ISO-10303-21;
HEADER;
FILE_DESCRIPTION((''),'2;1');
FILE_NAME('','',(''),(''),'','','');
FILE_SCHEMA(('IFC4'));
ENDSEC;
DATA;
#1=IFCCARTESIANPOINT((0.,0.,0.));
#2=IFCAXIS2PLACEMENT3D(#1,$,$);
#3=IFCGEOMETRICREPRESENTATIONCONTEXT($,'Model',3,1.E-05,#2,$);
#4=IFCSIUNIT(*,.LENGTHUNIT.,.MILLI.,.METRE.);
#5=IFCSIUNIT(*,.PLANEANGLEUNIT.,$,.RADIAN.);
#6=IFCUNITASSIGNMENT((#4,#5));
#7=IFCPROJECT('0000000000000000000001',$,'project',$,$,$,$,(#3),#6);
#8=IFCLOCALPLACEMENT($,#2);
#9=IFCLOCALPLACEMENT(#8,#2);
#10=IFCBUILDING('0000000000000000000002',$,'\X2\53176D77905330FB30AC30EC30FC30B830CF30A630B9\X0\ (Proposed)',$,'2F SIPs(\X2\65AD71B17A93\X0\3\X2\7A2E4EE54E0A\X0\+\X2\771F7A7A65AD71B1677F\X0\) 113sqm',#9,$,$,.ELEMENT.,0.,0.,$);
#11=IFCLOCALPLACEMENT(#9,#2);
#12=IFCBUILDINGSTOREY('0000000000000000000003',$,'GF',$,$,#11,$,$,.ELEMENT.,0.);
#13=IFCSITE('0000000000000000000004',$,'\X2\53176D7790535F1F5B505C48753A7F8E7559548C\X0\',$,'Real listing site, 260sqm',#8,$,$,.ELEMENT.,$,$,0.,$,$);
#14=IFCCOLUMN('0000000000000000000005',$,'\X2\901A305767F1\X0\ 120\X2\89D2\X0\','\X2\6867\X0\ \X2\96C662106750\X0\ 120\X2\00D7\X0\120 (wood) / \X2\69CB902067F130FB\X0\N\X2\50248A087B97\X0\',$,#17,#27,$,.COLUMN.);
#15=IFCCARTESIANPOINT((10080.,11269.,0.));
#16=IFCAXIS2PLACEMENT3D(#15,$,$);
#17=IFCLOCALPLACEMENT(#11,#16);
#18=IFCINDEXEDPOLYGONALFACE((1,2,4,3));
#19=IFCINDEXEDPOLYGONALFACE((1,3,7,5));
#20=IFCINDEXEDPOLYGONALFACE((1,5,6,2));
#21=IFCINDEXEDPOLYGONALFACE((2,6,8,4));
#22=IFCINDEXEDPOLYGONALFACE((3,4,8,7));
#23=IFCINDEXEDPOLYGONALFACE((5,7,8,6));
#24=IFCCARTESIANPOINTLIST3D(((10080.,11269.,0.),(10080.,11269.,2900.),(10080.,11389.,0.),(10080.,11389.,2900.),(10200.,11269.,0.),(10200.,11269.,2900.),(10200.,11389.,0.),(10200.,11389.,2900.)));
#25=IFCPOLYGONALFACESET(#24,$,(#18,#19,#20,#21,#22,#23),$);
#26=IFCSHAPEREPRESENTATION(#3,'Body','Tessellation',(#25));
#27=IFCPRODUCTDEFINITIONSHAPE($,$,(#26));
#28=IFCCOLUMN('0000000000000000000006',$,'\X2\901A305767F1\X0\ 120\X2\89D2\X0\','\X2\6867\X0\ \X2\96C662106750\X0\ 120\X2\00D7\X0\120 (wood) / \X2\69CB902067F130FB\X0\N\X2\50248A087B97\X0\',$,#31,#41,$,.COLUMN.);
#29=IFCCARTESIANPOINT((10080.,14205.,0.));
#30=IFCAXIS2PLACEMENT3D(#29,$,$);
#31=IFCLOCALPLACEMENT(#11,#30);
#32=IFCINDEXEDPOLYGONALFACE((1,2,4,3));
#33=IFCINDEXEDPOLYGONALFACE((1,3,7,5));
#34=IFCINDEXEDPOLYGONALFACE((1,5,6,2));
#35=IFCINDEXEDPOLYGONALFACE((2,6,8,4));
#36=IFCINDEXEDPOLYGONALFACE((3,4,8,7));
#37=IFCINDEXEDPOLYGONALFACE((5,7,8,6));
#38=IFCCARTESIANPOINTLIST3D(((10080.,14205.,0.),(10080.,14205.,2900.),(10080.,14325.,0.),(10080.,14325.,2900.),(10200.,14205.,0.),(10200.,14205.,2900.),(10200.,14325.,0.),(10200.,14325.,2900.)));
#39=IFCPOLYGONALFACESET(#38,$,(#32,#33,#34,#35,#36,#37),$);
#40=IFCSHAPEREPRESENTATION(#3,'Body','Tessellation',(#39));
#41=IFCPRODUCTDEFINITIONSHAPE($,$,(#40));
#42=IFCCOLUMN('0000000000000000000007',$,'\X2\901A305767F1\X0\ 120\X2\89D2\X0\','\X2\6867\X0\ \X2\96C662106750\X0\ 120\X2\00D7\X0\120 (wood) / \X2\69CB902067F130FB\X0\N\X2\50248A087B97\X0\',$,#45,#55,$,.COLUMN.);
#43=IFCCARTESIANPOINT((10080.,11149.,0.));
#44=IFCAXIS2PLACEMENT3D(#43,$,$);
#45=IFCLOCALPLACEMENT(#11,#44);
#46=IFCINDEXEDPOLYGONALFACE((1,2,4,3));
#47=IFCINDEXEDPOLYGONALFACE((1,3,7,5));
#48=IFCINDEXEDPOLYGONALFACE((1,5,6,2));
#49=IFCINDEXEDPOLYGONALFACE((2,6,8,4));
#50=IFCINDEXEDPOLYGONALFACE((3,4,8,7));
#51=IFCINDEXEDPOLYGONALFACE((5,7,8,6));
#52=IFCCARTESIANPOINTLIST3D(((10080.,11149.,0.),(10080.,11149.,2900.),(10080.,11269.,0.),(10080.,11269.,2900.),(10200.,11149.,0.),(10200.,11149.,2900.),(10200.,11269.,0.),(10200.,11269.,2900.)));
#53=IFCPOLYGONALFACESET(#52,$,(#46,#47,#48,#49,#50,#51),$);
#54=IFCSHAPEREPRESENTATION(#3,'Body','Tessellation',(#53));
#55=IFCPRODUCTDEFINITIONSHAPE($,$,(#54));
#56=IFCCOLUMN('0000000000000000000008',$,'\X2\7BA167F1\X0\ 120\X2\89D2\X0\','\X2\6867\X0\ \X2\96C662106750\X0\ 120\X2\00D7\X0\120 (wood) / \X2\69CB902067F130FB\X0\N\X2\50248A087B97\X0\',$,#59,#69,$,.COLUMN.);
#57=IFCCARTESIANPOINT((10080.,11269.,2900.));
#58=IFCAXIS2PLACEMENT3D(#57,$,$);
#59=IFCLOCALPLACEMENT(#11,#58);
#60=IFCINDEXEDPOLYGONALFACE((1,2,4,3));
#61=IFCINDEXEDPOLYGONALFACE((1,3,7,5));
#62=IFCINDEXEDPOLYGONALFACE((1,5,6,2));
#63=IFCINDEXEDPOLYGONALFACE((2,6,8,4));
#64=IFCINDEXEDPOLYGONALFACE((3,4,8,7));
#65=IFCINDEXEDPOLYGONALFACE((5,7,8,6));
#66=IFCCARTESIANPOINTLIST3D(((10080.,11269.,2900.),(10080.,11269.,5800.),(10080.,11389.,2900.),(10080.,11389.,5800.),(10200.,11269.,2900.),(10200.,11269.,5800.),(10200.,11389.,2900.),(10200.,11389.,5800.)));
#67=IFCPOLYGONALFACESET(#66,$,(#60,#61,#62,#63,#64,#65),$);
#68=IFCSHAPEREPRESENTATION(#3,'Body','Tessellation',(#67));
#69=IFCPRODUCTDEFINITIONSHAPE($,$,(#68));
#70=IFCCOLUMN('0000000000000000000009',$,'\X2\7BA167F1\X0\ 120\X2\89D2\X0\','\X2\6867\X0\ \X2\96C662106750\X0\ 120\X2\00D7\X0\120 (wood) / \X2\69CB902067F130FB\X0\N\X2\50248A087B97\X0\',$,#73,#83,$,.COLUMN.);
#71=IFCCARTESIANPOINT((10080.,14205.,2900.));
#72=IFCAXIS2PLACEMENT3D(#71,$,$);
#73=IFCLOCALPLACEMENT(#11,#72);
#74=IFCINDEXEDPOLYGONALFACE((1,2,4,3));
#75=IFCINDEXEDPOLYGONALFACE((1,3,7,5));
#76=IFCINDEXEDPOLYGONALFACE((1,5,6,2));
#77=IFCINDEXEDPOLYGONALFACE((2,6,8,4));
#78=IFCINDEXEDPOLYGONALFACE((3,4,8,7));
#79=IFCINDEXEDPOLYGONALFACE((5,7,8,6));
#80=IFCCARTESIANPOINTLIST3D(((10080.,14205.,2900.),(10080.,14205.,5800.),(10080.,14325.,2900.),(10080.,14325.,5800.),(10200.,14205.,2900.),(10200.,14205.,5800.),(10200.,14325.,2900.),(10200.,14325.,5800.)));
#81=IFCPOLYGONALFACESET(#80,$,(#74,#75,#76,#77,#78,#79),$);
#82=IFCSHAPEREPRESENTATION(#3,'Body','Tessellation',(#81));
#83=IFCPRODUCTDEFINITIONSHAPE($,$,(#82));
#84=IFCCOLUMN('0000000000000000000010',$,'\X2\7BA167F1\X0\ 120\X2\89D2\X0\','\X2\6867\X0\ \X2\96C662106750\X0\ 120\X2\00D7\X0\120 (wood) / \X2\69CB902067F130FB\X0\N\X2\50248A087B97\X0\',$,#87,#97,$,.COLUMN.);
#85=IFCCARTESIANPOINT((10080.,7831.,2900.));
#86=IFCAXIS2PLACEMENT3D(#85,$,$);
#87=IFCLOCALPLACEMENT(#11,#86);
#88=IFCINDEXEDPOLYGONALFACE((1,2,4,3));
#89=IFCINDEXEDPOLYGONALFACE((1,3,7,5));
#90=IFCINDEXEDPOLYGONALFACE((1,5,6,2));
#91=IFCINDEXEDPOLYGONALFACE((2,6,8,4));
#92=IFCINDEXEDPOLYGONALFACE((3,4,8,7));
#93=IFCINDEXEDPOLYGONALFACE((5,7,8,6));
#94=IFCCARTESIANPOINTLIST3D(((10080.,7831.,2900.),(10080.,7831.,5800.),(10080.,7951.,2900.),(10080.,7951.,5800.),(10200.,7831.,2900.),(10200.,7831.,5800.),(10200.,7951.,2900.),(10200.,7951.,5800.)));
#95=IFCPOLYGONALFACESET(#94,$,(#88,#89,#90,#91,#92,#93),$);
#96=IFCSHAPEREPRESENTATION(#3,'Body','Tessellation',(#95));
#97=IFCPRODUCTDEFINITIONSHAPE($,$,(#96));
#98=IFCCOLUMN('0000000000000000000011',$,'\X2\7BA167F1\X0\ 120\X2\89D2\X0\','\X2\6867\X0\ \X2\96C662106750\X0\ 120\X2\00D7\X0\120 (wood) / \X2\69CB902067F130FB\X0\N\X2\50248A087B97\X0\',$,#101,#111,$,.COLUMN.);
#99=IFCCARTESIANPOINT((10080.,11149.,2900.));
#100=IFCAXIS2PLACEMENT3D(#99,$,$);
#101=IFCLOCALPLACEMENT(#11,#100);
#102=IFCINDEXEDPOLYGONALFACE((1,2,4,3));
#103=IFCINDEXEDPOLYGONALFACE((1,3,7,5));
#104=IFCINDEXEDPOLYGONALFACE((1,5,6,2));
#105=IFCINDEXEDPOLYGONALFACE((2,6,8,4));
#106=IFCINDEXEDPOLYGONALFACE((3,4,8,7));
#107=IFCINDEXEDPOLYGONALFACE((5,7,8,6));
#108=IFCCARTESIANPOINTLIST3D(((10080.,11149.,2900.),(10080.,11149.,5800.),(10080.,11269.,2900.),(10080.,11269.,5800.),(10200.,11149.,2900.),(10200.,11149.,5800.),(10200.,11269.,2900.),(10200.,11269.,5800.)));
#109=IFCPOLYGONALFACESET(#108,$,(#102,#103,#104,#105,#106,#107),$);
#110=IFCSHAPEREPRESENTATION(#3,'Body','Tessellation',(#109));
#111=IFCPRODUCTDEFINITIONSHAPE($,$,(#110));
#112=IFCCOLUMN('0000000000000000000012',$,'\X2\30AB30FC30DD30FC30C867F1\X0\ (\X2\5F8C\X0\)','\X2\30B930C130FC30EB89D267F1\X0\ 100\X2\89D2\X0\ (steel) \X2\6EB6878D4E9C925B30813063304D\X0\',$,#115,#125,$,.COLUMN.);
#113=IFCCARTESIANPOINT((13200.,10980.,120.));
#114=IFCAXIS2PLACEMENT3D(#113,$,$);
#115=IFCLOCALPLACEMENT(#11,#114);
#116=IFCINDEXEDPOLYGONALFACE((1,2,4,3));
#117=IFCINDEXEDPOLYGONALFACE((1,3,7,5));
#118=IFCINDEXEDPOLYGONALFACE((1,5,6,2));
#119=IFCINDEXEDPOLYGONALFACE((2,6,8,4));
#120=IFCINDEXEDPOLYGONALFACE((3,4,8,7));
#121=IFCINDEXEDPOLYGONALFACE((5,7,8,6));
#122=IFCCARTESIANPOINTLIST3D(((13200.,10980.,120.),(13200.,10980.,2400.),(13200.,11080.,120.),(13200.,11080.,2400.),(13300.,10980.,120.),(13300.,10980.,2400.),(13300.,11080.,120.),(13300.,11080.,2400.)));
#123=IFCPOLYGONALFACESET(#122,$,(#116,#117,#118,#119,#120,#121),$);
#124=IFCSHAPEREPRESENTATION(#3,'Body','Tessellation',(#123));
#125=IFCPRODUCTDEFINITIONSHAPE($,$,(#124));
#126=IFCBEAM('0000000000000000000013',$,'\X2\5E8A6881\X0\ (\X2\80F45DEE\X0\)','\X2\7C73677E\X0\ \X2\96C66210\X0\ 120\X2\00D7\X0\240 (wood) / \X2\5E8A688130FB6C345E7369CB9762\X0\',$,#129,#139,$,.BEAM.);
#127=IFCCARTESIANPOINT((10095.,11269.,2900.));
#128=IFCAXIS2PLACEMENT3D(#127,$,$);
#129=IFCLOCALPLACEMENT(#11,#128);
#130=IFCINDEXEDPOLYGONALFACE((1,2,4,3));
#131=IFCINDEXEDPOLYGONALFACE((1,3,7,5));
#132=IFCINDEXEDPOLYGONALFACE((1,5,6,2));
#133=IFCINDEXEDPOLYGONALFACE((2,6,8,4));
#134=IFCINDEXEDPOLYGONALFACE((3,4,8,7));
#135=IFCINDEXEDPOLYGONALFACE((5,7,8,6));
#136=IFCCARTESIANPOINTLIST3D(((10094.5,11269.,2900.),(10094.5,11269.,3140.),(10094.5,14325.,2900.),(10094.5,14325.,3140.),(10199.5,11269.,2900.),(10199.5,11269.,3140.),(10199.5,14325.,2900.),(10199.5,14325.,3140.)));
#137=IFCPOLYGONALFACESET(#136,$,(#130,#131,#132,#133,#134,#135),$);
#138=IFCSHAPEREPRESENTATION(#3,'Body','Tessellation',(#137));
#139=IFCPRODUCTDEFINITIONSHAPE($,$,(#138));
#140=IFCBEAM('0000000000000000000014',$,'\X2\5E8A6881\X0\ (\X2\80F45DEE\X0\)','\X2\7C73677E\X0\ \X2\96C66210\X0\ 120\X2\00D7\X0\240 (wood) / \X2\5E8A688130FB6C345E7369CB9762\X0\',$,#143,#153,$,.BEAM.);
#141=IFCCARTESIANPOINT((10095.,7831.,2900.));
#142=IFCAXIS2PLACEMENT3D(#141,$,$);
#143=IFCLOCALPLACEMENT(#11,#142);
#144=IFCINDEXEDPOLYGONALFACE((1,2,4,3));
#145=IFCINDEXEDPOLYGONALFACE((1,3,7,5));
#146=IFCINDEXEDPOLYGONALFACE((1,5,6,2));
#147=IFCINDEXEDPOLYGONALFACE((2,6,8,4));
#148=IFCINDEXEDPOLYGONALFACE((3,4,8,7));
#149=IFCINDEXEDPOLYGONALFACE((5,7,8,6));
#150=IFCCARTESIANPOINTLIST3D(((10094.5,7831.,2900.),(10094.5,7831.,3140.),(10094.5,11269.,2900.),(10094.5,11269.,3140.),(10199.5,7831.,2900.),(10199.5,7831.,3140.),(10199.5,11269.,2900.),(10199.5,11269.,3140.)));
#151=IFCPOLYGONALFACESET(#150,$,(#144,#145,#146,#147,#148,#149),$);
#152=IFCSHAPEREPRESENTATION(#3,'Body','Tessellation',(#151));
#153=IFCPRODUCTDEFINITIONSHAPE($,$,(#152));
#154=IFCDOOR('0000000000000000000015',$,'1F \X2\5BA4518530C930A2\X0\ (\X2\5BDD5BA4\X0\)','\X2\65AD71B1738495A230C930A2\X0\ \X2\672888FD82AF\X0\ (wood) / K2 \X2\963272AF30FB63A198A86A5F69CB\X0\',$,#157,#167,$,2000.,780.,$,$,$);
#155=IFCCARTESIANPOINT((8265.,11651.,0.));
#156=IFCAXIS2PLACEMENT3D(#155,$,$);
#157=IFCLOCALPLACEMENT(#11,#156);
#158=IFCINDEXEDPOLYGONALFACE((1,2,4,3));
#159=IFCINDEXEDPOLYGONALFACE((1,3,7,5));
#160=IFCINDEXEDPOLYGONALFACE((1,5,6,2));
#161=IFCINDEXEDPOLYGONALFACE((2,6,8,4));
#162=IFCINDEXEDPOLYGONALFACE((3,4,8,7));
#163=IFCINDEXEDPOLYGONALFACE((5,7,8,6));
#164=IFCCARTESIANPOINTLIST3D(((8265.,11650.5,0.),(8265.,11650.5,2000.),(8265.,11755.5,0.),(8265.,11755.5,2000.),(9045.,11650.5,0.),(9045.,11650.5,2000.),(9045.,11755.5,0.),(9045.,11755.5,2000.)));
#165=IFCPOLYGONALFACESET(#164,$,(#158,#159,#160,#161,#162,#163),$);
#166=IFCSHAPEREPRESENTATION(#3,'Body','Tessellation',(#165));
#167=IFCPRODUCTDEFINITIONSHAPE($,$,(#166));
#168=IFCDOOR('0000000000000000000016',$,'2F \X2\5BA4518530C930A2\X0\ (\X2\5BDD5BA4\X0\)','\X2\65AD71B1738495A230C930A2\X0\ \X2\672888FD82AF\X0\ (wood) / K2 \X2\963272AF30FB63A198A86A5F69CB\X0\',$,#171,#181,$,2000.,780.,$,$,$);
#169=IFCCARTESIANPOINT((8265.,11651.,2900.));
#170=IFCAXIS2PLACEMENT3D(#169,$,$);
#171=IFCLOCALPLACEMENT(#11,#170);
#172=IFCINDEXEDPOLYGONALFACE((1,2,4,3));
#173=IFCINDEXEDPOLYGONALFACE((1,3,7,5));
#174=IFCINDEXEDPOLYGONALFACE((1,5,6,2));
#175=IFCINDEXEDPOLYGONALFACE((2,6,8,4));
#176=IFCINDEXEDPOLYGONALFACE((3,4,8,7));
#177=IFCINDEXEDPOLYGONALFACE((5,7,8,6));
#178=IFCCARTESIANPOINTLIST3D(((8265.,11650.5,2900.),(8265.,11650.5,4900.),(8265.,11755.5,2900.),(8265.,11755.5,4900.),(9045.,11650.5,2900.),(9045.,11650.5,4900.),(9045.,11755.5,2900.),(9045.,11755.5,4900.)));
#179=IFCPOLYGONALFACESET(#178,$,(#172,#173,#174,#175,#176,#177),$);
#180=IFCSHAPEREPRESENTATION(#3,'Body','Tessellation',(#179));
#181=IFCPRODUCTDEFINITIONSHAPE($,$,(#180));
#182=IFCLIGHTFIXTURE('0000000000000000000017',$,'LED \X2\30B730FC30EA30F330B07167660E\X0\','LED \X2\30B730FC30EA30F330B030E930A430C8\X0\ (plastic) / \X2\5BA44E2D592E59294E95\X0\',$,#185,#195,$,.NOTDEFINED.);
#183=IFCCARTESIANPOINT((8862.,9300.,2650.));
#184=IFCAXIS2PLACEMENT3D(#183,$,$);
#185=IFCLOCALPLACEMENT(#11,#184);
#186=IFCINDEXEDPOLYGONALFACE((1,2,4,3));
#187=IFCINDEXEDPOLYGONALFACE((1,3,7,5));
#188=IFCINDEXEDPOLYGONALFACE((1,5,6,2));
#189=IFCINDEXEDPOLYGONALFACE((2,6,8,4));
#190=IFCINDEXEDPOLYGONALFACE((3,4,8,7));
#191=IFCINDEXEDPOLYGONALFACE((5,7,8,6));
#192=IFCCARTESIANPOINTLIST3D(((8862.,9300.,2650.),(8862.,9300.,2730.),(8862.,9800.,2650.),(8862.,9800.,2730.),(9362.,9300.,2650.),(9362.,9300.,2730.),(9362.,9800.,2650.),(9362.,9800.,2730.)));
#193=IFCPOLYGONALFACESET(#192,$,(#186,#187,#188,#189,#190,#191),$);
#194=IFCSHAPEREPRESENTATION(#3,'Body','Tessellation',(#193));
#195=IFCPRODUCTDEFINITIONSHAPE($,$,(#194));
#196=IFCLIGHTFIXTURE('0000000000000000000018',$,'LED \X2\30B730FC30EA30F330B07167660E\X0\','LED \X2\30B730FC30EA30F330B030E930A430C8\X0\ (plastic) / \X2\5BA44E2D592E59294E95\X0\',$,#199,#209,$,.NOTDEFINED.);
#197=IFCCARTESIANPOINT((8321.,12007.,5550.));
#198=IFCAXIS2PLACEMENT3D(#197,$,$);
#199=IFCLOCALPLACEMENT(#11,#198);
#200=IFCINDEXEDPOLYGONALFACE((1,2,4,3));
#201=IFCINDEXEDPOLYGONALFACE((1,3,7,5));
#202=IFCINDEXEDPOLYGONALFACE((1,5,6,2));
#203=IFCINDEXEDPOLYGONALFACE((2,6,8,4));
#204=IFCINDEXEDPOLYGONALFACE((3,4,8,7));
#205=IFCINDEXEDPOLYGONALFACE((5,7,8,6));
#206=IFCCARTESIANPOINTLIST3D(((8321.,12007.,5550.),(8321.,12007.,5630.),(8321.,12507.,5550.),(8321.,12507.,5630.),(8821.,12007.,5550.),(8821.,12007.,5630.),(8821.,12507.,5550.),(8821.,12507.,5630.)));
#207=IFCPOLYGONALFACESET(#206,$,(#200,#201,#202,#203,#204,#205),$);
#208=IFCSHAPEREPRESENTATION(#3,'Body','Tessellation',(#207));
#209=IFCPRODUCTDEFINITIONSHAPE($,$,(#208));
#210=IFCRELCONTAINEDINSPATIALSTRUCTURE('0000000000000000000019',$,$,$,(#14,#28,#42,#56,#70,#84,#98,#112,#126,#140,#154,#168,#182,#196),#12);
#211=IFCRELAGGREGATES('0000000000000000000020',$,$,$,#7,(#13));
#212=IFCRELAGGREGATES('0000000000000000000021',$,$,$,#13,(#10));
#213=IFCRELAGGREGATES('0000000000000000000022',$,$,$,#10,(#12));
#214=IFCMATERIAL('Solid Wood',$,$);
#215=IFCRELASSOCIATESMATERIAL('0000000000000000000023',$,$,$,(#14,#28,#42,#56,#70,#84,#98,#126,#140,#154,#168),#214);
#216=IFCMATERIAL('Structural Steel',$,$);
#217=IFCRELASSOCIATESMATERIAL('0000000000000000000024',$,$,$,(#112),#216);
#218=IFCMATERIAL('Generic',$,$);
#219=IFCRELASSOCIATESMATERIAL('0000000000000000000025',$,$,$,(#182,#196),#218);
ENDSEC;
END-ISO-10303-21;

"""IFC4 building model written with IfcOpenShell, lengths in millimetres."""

from ifc_helpers import new_model, si_unit, frame, frame_2d, origin, place, context, project, spatial, rectangle, extrude, material, element, save


model = new_model("IFC4")

# Units and contexts
model_context = context("Model", 3, precision=1e-05, world=origin())
ifc_project = project(units=[si_unit("LENGTHUNIT", "METRE", prefix="MILLI"), si_unit("PLANEANGLEUNIT", "RADIAN")], contexts=[model_context])

# Site, building, storey
site_placement = place(None, origin())
site = spatial("IfcSite", under=ifc_project, at=site_placement, Name="北海道弟子屈町美留和", ObjectType="Real listing site, 260sqm", CompositionType="ELEMENT", RefElevation=0.0)
building_placement = place(site_placement, origin())
building = spatial("IfcBuilding", under=site, at=building_placement, Name="北海道・ガレージハウス (Proposed)", ObjectType="2F SIPs(断熱窓3種以上+真空断熱板) 113sqm", CompositionType="ELEMENT", ElevationOfRefHeight=0.0, ElevationOfTerrain=0.0)
storey_placement = place(building_placement, origin())
storey = spatial("IfcBuildingStorey", under=building, at=storey_placement, Name="GF", CompositionType="ELEMENT", Elevation=0.0)

# Columns
ifc_material_1 = material(Name="Solid Wood")
column_1_placement = place(storey_placement, frame((10080.0, 11269.0, 0.0)))
element("IfcColumn", 1, at=column_1_placement, inside=storey, material=ifc_material_1, Name="通し柱 120角", Description="桧 集成材 120×120 (wood) / 構造柱・N値計算", PredefinedType="COLUMN", context=model_context, shape_type="SweptSolid", body=[
    extrude(rectangle(XDim=120.0, YDim=120.0, at=frame_2d((60.0, 60.0))), frame((10080.0, 11269.0, 0.0)), (0.0, 0.0, 1.0), 2900.0),
])
column_2_placement = place(storey_placement, frame((10080.0, 14205.0, 0.0)))
element("IfcColumn", 2, at=column_2_placement, inside=storey, material=ifc_material_1, Name="通し柱 120角", Description="桧 集成材 120×120 (wood) / 構造柱・N値計算", PredefinedType="COLUMN", context=model_context, shape_type="SweptSolid", body=[
    extrude(rectangle(XDim=120.0, YDim=120.0, at=frame_2d((60.0, 60.0))), frame((10080.0, 14205.0, 0.0)), (0.0, 0.0, 1.0), 2900.0),
])
column_3_placement = place(storey_placement, frame((10080.0, 11149.0, 0.0)))
element("IfcColumn", 3, at=column_3_placement, inside=storey, material=ifc_material_1, Name="通し柱 120角", Description="桧 集成材 120×120 (wood) / 構造柱・N値計算", PredefinedType="COLUMN", context=model_context, shape_type="SweptSolid", body=[
    extrude(rectangle(XDim=120.0, YDim=120.0, at=frame_2d((60.0, 60.0))), frame((10080.0, 11149.0, 0.0)), (0.0, 0.0, 1.0), 2900.0),
])
column_4_placement = place(storey_placement, frame((10080.0, 11269.0, 2900.0)))
element("IfcColumn", 4, at=column_4_placement, inside=storey, material=ifc_material_1, Name="管柱 120角", Description="桧 集成材 120×120 (wood) / 構造柱・N値計算", PredefinedType="COLUMN", context=model_context, shape_type="SweptSolid", body=[
    extrude(rectangle(XDim=120.0, YDim=120.0, at=frame_2d((60.0, 60.0))), frame((10080.0, 11269.0, 2900.0)), (0.0, 0.0, 1.0), 2900.0),
])
column_5_placement = place(storey_placement, frame((10080.0, 14205.0, 2900.0)))
element("IfcColumn", 5, at=column_5_placement, inside=storey, material=ifc_material_1, Name="管柱 120角", Description="桧 集成材 120×120 (wood) / 構造柱・N値計算", PredefinedType="COLUMN", context=model_context, shape_type="SweptSolid", body=[
    extrude(rectangle(XDim=120.0, YDim=120.0, at=frame_2d((60.0, 60.0))), frame((10080.0, 14205.0, 2900.0)), (0.0, 0.0, 1.0), 2900.0),
])
column_6_placement = place(storey_placement, frame((10080.0, 7831.0, 2900.0)))
element("IfcColumn", 6, at=column_6_placement, inside=storey, material=ifc_material_1, Name="管柱 120角", Description="桧 集成材 120×120 (wood) / 構造柱・N値計算", PredefinedType="COLUMN", context=model_context, shape_type="SweptSolid", body=[
    extrude(rectangle(XDim=120.0, YDim=120.0, at=frame_2d((60.0, 60.0))), frame((10080.0, 7831.0, 2900.0)), (0.0, 0.0, 1.0), 2900.0),
])
column_7_placement = place(storey_placement, frame((10080.0, 11149.0, 2900.0)))
element("IfcColumn", 7, at=column_7_placement, inside=storey, material=ifc_material_1, Name="管柱 120角", Description="桧 集成材 120×120 (wood) / 構造柱・N値計算", PredefinedType="COLUMN", context=model_context, shape_type="SweptSolid", body=[
    extrude(rectangle(XDim=120.0, YDim=120.0, at=frame_2d((60.0, 60.0))), frame((10080.0, 11149.0, 2900.0)), (0.0, 0.0, 1.0), 2900.0),
])
ifc_material_2 = material(Name="Structural Steel")
column_8_placement = place(storey_placement, frame((13200.0, 10980.0, 120.0)))
element("IfcColumn", 8, at=column_8_placement, inside=storey, material=ifc_material_2, Name="カーポート柱 (後)", Description="スチール角柱 100角 (steel) 溶融亜鉛めっき", PredefinedType="COLUMN", context=model_context, shape_type="SweptSolid", body=[
    extrude(rectangle(XDim=100.0, YDim=100.0, at=frame_2d((50.0, 50.0))), frame((13200.0, 10980.0, 120.0)), (0.0, 0.0, 1.0), 2280.0),
])

# Beams
beam_1_placement = place(storey_placement, frame((10095.0, 11269.0, 2900.0)))
element("IfcBeam", 9, at=beam_1_placement, inside=storey, material=ifc_material_1, Name="床梁 (胴差)", Description="米松 集成 120×240 (wood) / 床梁・水平構面", PredefinedType="BEAM", context=model_context, shape_type="SweptSolid", body=[
    extrude(rectangle(XDim=105.0, YDim=3056.0, at=frame_2d((52.0, 1528.0))), frame((10095.0, 11269.0, 2900.0)), (0.0, 0.0, 1.0), 240.0),
])
beam_2_placement = place(storey_placement, frame((10095.0, 7831.0, 2900.0)))
element("IfcBeam", 10, at=beam_2_placement, inside=storey, material=ifc_material_1, Name="床梁 (胴差)", Description="米松 集成 120×240 (wood) / 床梁・水平構面", PredefinedType="BEAM", context=model_context, shape_type="SweptSolid", body=[
    extrude(rectangle(XDim=105.0, YDim=3438.0, at=frame_2d((52.0, 1719.0))), frame((10095.0, 7831.0, 2900.0)), (0.0, 0.0, 1.0), 240.0),
])

# Doors
door_1_placement = place(storey_placement, frame((8265.0, 11651.0, 0.0)))
element("IfcDoor", 11, at=door_1_placement, inside=storey, material=ifc_material_1, Name="1F 室内ドア (寝室)", Description="断熱玄関ドア 木製芯 (wood) / K2 防犯・採風機構", OverallHeight=2000.0, OverallWidth=780.0, context=model_context, shape_type="SweptSolid", body=[
    extrude(rectangle(XDim=780.0, YDim=105.0, at=frame_2d((390.0, 52.0))), frame((8265.0, 11651.0, 0.0)), (0.0, 0.0, 1.0), 2000.0),
])
door_2_placement = place(storey_placement, frame((8265.0, 11651.0, 2900.0)))
element("IfcDoor", 12, at=door_2_placement, inside=storey, material=ifc_material_1, Name="2F 室内ドア (寝室)", Description="断熱玄関ドア 木製芯 (wood) / K2 防犯・採風機構", OverallHeight=2000.0, OverallWidth=780.0, context=model_context, shape_type="SweptSolid", body=[
    extrude(rectangle(XDim=780.0, YDim=105.0, at=frame_2d((390.0, 52.0))), frame((8265.0, 11651.0, 2900.0)), (0.0, 0.0, 1.0), 2000.0),
])

# Light fixtures
ifc_material_3 = material(Name="Generic")
light_fixture_1_placement = place(storey_placement, frame((8862.0, 9300.0, 2650.0)))
element("IfcLightFixture", 13, at=light_fixture_1_placement, inside=storey, material=ifc_material_3, Name="LED シーリング照明", Description="LED シーリングライト (plastic) / 室中央天井", PredefinedType="NOTDEFINED", context=model_context, shape_type="SweptSolid", body=[
    extrude(rectangle(XDim=500.0, YDim=500.0, at=frame_2d((250.0, 250.0))), frame((8862.0, 9300.0, 2650.0)), (0.0, 0.0, 1.0), 80.0),
])
light_fixture_2_placement = place(storey_placement, frame((8321.0, 12007.0, 5550.0)))
element("IfcLightFixture", 14, at=light_fixture_2_placement, inside=storey, material=ifc_material_3, Name="LED シーリング照明", Description="LED シーリングライト (plastic) / 室中央天井", PredefinedType="NOTDEFINED", context=model_context, shape_type="SweptSolid", body=[
    extrude(rectangle(XDim=500.0, YDim=500.0, at=frame_2d((250.0, 250.0))), frame((8321.0, 12007.0, 5550.0)), (0.0, 0.0, 1.0), 80.0),
])

save(model, "model.ifc")
